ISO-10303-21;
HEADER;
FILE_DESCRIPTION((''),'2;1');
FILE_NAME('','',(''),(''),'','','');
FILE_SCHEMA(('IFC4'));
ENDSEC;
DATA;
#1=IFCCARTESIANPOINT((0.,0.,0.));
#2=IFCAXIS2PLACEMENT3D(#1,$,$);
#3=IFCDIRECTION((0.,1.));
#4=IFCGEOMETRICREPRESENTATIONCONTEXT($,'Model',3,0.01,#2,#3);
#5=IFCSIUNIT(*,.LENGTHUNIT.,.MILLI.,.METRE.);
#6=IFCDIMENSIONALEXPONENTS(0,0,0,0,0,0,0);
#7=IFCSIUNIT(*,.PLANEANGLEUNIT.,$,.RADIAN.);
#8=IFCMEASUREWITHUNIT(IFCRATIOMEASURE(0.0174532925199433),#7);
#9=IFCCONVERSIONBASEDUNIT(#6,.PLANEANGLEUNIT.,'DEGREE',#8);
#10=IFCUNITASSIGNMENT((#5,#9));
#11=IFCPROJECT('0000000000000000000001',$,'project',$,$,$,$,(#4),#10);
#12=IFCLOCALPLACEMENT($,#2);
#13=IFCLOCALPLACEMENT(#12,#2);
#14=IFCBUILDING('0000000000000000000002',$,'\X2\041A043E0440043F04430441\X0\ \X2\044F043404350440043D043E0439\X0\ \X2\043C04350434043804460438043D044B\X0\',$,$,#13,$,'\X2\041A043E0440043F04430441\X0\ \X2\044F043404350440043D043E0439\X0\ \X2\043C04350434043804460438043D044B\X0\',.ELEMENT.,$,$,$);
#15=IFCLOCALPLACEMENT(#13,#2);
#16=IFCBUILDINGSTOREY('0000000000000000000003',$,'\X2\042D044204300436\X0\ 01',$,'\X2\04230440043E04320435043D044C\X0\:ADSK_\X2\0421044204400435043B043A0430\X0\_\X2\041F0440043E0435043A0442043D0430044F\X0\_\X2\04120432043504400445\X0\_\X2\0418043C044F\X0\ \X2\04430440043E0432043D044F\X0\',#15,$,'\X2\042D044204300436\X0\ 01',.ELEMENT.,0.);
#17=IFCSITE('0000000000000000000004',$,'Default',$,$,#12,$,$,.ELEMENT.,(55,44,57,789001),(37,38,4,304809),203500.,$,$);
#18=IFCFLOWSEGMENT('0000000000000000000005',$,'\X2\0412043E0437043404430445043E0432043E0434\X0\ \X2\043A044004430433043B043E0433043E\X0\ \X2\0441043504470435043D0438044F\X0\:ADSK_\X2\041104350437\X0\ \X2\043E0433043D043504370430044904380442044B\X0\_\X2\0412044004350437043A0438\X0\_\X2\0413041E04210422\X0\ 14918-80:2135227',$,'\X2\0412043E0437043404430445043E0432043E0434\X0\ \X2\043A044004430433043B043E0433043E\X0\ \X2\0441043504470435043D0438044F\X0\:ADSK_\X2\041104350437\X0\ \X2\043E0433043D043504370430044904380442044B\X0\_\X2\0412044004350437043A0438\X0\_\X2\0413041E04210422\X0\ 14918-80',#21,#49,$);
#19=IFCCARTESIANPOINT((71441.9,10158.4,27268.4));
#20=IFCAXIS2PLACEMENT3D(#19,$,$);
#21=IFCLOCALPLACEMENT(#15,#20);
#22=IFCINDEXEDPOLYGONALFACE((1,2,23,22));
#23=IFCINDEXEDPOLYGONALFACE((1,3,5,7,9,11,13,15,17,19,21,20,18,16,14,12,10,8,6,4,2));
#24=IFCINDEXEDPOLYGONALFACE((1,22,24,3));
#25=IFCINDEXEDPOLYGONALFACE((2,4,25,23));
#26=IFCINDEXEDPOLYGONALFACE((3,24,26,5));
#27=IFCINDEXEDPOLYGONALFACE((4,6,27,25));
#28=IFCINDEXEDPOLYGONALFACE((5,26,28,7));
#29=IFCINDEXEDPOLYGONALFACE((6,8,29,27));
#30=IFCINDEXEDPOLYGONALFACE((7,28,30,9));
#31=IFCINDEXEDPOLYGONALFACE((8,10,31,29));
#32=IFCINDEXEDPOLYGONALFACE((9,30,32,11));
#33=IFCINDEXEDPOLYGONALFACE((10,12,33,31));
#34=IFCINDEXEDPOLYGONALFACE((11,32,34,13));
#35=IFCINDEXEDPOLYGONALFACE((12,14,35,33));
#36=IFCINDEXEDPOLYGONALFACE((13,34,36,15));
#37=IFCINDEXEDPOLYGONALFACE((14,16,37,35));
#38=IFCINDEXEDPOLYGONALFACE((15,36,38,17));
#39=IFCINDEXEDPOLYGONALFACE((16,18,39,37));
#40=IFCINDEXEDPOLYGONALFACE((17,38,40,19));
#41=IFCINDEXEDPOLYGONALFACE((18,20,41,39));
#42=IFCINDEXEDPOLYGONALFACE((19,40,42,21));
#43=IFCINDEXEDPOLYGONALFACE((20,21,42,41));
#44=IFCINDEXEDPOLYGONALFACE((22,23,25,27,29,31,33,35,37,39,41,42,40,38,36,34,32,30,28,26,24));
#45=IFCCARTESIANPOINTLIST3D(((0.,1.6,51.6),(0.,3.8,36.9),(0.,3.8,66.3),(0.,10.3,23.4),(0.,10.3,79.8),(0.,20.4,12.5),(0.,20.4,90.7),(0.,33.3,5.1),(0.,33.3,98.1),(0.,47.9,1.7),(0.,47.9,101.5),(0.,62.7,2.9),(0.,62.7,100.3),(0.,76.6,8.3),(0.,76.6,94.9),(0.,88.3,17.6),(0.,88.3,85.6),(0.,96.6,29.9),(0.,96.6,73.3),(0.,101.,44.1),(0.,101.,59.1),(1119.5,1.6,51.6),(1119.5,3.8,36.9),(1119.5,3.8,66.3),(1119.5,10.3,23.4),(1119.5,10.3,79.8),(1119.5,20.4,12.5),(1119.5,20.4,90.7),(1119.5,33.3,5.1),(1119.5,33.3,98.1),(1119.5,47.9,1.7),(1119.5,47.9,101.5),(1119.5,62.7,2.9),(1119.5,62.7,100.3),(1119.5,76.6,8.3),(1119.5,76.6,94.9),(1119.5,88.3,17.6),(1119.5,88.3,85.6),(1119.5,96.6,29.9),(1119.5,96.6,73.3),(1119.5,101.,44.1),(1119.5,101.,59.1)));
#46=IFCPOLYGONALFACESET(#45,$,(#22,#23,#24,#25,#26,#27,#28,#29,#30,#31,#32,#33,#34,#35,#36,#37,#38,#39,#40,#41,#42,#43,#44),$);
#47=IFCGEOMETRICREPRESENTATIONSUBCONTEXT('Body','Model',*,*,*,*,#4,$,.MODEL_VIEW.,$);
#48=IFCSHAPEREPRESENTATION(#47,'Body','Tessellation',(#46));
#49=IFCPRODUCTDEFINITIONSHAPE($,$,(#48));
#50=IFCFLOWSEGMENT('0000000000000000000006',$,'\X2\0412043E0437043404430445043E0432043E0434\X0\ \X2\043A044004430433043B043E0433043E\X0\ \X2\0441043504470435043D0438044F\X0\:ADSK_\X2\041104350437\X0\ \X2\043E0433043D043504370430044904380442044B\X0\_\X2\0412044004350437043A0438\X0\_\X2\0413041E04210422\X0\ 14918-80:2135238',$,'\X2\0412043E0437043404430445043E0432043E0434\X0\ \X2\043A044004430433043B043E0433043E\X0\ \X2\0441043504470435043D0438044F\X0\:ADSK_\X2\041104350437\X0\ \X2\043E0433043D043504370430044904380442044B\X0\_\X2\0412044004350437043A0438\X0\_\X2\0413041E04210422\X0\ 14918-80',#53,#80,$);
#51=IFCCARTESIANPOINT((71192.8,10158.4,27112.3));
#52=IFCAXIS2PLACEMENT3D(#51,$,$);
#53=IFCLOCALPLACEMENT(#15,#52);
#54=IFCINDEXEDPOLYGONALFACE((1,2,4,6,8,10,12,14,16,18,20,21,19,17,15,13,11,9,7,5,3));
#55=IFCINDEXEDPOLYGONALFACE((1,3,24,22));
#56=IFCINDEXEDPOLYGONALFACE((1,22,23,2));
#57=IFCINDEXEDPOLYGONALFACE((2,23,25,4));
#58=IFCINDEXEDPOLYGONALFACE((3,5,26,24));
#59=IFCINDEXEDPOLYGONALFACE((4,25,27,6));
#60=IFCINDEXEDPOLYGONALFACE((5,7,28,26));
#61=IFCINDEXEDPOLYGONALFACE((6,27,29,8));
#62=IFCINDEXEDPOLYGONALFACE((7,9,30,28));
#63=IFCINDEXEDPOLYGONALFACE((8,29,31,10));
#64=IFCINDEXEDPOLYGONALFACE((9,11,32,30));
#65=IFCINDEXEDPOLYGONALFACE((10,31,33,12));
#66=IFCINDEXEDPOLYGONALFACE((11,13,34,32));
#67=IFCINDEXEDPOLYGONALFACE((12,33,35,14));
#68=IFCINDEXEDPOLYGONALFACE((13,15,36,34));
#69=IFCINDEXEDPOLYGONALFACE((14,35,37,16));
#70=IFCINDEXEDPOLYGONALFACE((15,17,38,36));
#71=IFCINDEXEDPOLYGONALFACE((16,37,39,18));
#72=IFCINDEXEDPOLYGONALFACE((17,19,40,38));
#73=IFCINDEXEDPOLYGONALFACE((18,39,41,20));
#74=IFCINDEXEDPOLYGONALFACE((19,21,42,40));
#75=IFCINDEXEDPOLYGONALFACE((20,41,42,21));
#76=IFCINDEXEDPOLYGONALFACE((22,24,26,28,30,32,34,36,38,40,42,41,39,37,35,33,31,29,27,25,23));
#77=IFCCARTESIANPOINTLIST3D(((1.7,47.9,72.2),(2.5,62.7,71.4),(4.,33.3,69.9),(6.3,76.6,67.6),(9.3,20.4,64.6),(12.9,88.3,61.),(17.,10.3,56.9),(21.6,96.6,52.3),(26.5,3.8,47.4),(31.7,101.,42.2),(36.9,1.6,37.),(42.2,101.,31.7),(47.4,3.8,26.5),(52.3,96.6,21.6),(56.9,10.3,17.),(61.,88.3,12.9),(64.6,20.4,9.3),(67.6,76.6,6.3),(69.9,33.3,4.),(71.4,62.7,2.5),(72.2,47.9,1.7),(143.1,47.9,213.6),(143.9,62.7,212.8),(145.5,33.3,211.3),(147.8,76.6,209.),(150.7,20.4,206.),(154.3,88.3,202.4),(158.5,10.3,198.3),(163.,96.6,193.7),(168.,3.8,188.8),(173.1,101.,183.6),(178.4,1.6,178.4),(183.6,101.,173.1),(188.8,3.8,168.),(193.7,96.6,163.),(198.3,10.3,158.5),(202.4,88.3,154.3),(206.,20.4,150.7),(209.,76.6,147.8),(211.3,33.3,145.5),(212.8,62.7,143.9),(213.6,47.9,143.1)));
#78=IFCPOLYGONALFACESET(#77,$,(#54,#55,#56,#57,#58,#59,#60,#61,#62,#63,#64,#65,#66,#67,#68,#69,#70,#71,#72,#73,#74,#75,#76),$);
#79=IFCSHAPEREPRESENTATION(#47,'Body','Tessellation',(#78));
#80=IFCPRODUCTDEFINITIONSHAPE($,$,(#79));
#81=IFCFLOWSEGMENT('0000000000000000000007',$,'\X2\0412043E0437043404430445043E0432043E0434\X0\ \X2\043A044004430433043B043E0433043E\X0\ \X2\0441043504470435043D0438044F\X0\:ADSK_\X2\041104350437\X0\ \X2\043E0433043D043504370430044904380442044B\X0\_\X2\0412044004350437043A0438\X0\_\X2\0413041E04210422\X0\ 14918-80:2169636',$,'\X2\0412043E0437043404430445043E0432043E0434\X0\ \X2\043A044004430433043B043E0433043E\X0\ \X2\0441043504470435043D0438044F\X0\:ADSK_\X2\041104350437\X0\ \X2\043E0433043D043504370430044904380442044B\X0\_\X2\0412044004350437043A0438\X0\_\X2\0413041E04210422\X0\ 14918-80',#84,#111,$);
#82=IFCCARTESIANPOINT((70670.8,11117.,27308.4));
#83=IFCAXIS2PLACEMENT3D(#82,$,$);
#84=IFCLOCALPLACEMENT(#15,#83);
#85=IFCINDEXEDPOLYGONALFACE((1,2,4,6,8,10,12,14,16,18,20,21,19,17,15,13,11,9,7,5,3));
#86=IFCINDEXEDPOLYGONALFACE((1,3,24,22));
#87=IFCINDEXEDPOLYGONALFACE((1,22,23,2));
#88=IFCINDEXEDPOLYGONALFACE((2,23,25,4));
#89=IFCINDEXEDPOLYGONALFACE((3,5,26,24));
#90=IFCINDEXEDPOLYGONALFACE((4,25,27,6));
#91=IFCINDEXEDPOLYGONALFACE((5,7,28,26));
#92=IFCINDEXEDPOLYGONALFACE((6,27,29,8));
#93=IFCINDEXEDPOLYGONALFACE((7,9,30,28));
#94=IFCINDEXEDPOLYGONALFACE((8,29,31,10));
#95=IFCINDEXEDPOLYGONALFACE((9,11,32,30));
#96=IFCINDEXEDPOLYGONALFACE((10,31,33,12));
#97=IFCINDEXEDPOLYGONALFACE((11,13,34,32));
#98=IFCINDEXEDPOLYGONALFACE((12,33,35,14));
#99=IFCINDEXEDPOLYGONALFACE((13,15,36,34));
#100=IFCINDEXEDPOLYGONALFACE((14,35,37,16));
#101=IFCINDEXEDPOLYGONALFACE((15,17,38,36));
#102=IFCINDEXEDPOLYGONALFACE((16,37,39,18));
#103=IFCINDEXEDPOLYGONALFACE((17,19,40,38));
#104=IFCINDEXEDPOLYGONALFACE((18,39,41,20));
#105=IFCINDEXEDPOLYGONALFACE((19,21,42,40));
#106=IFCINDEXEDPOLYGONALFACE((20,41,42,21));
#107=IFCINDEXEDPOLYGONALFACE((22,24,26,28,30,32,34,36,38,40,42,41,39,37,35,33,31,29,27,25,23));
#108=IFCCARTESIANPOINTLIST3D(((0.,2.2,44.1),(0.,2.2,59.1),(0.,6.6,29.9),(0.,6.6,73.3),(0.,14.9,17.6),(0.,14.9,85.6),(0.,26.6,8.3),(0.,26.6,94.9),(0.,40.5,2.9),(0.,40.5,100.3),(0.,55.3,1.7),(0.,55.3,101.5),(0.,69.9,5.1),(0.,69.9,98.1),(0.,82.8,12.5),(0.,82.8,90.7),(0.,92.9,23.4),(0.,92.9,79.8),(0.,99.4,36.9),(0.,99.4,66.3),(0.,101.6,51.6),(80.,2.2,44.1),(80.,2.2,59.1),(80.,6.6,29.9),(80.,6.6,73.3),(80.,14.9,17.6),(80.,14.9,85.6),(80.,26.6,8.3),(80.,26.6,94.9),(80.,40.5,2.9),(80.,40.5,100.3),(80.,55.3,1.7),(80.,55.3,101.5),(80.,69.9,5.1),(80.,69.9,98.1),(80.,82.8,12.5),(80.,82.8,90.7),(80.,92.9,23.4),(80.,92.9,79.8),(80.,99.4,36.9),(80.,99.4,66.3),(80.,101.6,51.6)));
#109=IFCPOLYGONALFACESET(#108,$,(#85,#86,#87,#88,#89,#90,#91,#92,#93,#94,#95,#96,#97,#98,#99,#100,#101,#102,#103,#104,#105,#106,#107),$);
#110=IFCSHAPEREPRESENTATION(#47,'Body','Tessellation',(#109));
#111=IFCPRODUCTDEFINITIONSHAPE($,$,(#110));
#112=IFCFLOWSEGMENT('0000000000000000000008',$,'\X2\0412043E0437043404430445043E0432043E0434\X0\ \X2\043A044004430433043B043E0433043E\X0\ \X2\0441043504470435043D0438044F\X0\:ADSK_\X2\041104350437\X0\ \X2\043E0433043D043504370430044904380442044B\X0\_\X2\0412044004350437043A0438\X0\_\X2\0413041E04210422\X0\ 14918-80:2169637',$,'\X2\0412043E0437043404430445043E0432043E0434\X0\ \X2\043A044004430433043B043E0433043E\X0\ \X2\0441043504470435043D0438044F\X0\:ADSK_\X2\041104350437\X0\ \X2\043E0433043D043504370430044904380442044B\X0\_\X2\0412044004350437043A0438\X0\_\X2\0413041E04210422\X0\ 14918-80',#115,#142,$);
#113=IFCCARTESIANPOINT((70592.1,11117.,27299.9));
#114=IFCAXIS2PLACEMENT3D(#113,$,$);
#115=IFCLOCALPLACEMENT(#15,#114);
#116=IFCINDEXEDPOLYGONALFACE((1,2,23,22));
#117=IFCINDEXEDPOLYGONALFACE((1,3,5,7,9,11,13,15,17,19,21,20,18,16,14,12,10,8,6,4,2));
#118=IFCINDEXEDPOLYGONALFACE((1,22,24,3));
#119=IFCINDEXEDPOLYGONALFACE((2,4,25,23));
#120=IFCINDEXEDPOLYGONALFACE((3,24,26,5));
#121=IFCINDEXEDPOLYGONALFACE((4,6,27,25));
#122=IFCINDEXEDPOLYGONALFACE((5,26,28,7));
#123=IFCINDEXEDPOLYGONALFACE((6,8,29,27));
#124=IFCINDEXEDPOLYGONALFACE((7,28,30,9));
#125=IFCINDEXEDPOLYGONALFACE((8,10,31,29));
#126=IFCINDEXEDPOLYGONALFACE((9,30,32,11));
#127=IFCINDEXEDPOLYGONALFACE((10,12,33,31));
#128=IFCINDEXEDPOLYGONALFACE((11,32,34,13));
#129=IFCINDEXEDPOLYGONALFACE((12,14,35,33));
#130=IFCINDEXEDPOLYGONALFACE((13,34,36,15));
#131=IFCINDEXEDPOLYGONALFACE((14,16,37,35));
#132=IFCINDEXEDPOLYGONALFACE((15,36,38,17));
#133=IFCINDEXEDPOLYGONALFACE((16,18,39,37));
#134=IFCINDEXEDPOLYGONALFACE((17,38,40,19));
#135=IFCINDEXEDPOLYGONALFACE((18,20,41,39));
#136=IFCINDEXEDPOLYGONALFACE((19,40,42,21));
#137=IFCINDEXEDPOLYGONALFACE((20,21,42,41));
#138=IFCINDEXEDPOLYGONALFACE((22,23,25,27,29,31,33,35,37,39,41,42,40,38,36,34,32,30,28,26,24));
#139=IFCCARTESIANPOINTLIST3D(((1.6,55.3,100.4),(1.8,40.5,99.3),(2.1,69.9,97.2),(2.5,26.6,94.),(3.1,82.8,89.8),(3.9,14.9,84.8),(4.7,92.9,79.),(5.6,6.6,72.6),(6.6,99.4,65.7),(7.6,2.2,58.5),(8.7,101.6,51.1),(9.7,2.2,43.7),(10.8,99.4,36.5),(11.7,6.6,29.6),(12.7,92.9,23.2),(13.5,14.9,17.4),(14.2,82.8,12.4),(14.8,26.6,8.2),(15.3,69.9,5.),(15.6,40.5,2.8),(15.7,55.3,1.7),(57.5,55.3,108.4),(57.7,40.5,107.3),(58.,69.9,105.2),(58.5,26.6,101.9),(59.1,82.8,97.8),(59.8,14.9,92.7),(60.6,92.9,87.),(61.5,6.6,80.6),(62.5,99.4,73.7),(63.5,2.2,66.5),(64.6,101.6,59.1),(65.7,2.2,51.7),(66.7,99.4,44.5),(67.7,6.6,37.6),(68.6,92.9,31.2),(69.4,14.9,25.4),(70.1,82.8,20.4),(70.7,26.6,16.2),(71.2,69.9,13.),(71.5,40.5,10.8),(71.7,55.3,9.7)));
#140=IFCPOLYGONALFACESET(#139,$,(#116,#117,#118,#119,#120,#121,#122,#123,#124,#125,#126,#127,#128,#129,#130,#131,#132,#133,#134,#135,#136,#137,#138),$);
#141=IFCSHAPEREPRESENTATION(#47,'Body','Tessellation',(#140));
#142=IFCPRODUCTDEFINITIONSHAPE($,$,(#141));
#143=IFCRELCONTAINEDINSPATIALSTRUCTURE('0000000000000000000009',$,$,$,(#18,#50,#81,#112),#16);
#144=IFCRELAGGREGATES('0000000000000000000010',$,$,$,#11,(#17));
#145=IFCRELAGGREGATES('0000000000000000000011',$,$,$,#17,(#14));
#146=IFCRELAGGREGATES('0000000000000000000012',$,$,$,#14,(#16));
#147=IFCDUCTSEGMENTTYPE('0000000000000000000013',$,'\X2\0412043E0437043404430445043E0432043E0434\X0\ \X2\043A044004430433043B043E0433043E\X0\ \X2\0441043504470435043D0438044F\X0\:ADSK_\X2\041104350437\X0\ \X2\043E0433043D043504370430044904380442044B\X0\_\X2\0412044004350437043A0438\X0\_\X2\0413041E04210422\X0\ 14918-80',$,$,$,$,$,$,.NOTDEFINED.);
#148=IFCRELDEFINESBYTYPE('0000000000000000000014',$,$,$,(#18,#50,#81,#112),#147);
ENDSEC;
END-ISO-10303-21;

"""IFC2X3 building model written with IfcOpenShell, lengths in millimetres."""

from ifc_helpers import new_model, entity, si_unit, converted_unit, direction, frame, origin, origin_2d_with_axis, place, context, subcontext, project, spatial, circle, extrude, type_object, element, save


model = new_model("IFC2X3")

# Units and contexts
model_context = context("Model", 3, precision=0.01, world=origin(), true_north=direction((0.0, 1.0)))
body_context = subcontext(model_context, "Body", "Model", "MODEL_VIEW")
ifc_project = project(units=[si_unit("LENGTHUNIT", "METRE", prefix="MILLI"), converted_unit("PLANEANGLEUNIT", "DEGREE", entity("IfcRatioMeasure", 0.0174532925199433), si_unit("PLANEANGLEUNIT", "RADIAN"), dimensions=[0, 0, 0, 0, 0, 0, 0])], contexts=[model_context])

# Site, building, storey
site_placement = place(None, origin())
site = spatial("IfcSite", under=ifc_project, at=site_placement, Name="Default", CompositionType="ELEMENT", RefLatitude=(55, 44, 57, 789001), RefLongitude=(37, 38, 4, 304809), RefElevation=203500.0)
building_placement = place(site_placement, origin())
building = spatial("IfcBuilding", under=site, at=building_placement, Name="Корпус ядерной медицины", LongName="Корпус ядерной медицины", CompositionType="ELEMENT")
storey_placement = place(building_placement, origin())
storey = spatial("IfcBuildingStorey", under=building, at=storey_placement, Name="Этаж 01", ObjectType="Уровень:ADSK_Стрелка_Проектная_Вверх_Имя уровня", LongName="Этаж 01", CompositionType="ELEMENT", Elevation=0.0)

# Flow segments
duct_segment_type_1 = type_object("IfcDuctSegmentType", Name="Воздуховод круглого сечения:ADSK_Без огнезащиты_Врезки_ГОСТ 14918-80", PredefinedType="NOTDEFINED")
flow_segment_1_placement = place(storey_placement, frame((71441.9, 10158.4, 27268.4)))
element("IfcFlowSegment", 1, at=flow_segment_1_placement, inside=storey, type_object=duct_segment_type_1, Name="Воздуховод круглого сечения:ADSK_Без огнезащиты_Врезки_ГОСТ 14918-80:2135227", ObjectType="Воздуховод круглого сечения:ADSK_Без огнезащиты_Врезки_ГОСТ 14918-80", context=body_context, shape_type="SweptSolid", body=[
    extrude(circle(Radius=50.0, at=origin_2d_with_axis()), frame((0.0, 51.6, 51.6), z_axis=(1.0, 0.0, 0.0), x_axis=(0.0, -1.0, 0.0)), (0.0, 0.0, 1.0), 1119.5),
])
flow_segment_2_placement = place(storey_placement, frame((71192.8, 10158.4, 27112.3)))
element("IfcFlowSegment", 2, at=flow_segment_2_placement, inside=storey, type_object=duct_segment_type_1, Name="Воздуховод круглого сечения:ADSK_Без огнезащиты_Врезки_ГОСТ 14918-80:2135238", ObjectType="Воздуховод круглого сечения:ADSK_Без огнезащиты_Врезки_ГОСТ 14918-80", context=body_context, shape_type="SweptSolid", body=[
    extrude(circle(Radius=50.0, at=origin_2d_with_axis()), frame((37.0, 51.6, 37.0), z_axis=(0.707107, 0.0, 0.707107), x_axis=(0.0, -1.0, 0.0)), (0.0, 0.0, 1.0), 200.0),
])
flow_segment_3_placement = place(storey_placement, frame((70670.8, 11117.0, 27308.4)))
element("IfcFlowSegment", 3, at=flow_segment_3_placement, inside=storey, type_object=duct_segment_type_1, Name="Воздуховод круглого сечения:ADSK_Без огнезащиты_Врезки_ГОСТ 14918-80:2169636", ObjectType="Воздуховод круглого сечения:ADSK_Без огнезащиты_Врезки_ГОСТ 14918-80", context=body_context, shape_type="SweptSolid", body=[
    extrude(circle(Radius=50.0, at=origin_2d_with_axis()), frame((0.0, 51.6, 51.6), z_axis=(1.0, 0.0, 0.0), x_axis=(0.0, 1.0, 0.0)), (0.0, 0.0, 1.0), 80.0),
])
flow_segment_4_placement = place(storey_placement, frame((70592.1, 11117.0, 27299.9)))
element("IfcFlowSegment", 4, at=flow_segment_4_placement, inside=storey, type_object=duct_segment_type_1, Name="Воздуховод круглого сечения:ADSK_Без огнезащиты_Врезки_ГОСТ 14918-80:2169637", ObjectType="Воздуховод круглого сечения:ADSK_Без огнезащиты_Врезки_ГОСТ 14918-80", context=body_context, shape_type="SweptSolid", body=[
    extrude(circle(Radius=50.0, at=origin_2d_with_axis()), frame((8.7, 51.6, 51.1), z_axis=(0.989949, 0.0, 0.141422), x_axis=(0.0, 1.0, 0.0)), (0.0, 0.0, 1.0), 56.5),
])

save(model, "model.ifc")
